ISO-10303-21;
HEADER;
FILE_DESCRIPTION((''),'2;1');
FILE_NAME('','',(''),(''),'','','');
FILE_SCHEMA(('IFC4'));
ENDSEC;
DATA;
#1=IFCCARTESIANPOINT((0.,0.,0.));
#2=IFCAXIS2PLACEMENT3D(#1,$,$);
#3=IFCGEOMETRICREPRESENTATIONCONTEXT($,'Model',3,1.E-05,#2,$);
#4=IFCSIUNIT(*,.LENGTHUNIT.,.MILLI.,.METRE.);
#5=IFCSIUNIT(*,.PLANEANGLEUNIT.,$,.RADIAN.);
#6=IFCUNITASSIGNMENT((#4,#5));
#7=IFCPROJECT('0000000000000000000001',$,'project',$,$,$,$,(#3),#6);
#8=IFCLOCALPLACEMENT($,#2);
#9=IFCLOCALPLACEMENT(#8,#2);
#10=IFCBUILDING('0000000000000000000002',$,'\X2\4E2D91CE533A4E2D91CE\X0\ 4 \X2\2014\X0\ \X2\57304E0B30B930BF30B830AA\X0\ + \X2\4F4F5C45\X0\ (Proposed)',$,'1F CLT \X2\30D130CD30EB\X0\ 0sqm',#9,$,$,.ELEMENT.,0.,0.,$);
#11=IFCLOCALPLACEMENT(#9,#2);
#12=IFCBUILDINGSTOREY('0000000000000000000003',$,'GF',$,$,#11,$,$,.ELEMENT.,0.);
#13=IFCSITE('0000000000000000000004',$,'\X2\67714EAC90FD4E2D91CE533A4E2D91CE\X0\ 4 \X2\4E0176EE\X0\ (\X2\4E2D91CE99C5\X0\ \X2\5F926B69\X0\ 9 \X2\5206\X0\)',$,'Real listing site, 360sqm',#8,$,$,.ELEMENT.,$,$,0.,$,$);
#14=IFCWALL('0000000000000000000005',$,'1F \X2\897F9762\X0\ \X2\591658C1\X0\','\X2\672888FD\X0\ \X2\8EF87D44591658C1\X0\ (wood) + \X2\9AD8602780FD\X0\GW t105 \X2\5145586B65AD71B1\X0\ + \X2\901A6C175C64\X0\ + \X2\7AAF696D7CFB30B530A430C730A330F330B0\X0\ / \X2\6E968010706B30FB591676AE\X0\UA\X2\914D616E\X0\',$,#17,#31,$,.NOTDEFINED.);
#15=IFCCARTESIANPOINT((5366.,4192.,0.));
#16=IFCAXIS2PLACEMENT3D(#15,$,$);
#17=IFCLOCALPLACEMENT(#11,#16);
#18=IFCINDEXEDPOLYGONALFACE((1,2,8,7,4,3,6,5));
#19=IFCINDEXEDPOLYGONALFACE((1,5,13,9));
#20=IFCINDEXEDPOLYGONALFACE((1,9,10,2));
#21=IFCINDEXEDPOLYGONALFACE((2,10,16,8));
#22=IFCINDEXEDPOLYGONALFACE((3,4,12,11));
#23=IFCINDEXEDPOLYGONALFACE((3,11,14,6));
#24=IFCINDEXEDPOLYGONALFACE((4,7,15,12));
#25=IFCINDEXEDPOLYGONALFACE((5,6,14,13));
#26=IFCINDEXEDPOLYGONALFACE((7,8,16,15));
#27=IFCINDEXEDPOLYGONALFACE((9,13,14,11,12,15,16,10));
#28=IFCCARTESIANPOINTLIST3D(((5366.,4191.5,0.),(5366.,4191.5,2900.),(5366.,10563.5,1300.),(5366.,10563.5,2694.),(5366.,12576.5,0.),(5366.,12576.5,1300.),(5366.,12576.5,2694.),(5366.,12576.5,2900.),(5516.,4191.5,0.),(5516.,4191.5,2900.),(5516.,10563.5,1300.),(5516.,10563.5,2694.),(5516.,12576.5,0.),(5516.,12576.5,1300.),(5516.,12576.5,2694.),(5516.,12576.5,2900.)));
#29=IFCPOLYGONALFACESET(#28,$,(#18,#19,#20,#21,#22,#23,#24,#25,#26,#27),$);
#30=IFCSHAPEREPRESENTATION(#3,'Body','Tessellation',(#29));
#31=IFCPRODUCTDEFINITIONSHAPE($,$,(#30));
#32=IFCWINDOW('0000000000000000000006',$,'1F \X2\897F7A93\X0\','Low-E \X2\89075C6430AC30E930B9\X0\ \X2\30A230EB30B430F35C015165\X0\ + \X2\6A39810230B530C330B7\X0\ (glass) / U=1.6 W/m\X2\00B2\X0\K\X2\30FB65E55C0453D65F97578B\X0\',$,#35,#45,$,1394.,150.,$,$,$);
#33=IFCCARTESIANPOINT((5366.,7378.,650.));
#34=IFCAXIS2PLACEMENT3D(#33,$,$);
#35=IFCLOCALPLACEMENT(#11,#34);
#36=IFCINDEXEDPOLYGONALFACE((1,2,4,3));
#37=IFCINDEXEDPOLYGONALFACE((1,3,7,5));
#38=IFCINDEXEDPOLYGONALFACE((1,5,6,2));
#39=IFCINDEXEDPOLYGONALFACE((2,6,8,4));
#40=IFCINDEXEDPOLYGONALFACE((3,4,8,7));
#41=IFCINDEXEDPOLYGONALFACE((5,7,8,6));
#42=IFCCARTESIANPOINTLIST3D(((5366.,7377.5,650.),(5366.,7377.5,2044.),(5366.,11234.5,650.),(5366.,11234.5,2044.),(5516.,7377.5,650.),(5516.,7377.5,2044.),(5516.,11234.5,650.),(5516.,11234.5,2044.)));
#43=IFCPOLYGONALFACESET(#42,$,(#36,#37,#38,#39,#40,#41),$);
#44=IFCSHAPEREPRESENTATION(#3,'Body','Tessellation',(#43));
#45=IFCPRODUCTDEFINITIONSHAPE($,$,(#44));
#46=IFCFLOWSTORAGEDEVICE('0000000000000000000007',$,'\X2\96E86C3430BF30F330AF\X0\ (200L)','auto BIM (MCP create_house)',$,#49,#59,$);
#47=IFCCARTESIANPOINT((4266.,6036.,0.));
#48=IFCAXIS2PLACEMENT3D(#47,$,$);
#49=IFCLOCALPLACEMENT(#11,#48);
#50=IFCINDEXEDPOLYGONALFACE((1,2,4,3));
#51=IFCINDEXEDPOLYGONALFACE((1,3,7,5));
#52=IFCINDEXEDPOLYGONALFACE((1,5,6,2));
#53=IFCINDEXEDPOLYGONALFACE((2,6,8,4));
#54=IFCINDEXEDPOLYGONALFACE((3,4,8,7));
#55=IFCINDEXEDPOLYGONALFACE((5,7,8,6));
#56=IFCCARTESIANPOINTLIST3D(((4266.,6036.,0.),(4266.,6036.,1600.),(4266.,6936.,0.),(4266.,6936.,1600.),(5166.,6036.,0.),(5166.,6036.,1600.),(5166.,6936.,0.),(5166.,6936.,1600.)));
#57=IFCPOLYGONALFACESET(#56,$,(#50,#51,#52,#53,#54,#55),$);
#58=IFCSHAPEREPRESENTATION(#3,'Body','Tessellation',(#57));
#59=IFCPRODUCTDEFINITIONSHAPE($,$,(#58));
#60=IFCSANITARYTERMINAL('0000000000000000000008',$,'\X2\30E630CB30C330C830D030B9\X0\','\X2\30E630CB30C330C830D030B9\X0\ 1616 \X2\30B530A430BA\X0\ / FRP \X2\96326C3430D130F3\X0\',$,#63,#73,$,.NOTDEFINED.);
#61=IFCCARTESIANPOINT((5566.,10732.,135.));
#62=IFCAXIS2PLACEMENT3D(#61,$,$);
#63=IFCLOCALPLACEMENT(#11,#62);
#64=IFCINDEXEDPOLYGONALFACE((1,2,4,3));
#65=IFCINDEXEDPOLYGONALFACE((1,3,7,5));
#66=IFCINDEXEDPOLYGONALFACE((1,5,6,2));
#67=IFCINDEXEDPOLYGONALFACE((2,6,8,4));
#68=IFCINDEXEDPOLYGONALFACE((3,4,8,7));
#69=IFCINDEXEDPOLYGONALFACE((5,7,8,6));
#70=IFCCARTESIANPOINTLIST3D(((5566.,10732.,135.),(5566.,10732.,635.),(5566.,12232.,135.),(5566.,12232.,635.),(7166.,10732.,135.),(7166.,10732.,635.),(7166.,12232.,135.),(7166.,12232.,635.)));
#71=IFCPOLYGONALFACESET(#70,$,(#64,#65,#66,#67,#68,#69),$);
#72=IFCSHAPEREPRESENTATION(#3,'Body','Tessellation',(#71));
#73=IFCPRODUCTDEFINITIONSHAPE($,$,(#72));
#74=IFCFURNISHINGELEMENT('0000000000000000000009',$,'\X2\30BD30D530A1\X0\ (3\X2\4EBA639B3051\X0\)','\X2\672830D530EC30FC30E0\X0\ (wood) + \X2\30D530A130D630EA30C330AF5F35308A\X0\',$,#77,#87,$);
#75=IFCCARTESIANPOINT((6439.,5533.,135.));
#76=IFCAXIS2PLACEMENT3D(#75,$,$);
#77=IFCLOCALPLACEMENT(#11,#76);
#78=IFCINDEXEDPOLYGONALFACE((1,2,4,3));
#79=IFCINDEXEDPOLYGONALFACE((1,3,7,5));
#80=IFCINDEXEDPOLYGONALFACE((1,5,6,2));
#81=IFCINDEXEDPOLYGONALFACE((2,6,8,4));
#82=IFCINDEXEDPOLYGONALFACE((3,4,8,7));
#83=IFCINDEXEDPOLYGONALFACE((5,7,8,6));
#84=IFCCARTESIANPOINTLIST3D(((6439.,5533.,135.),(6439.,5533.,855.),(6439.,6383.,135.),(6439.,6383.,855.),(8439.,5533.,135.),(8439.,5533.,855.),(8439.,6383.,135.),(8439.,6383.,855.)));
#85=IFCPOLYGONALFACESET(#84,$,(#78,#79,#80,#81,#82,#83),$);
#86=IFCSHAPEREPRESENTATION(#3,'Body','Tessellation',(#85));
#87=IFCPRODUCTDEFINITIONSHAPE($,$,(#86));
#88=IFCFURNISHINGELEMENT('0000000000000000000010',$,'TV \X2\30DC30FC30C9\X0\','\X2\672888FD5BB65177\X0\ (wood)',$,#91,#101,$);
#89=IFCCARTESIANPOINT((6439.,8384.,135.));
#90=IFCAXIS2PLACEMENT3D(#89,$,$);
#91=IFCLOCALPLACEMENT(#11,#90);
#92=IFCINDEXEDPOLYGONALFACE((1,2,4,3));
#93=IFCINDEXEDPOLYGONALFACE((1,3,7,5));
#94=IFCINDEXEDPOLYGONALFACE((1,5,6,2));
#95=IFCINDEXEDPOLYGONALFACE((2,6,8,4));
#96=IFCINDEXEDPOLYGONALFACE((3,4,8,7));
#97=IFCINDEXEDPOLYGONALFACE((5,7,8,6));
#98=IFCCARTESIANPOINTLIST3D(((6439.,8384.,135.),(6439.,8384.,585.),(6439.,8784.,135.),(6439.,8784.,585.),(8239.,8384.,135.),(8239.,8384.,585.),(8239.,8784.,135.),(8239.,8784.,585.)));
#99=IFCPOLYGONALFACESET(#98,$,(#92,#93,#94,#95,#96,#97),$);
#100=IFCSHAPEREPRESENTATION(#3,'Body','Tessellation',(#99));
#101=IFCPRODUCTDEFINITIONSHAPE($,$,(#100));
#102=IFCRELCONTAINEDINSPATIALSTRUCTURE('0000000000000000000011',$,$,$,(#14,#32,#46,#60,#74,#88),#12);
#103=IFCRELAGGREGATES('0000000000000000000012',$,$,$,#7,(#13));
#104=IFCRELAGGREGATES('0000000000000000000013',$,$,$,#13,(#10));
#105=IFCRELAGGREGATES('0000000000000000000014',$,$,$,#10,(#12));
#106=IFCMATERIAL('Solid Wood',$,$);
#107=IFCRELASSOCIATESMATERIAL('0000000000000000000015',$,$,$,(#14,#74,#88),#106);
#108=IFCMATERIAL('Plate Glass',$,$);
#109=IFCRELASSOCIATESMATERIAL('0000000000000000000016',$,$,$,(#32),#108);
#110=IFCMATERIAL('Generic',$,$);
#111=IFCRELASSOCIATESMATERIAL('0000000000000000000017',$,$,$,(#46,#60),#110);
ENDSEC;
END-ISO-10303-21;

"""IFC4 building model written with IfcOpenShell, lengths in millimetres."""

from ifc_helpers import new_model, si_unit, frame, frame_2d, origin, place, context, project, spatial, rectangle, extrude, material, element, fill, save


model = new_model("IFC4")

# Units and contexts
model_context = context("Model", 3, precision=1e-05, world=origin())
ifc_project = project(units=[si_unit("LENGTHUNIT", "METRE", prefix="MILLI"), si_unit("PLANEANGLEUNIT", "RADIAN")], contexts=[model_context])

# Site, building, storey
site_placement = place(None, origin())
site = spatial("IfcSite", under=ifc_project, at=site_placement, Name="東京都中野区中野 4 丁目 (中野駅 徒歩 9 分)", ObjectType="Real listing site, 360sqm", CompositionType="ELEMENT", RefElevation=0.0)
building_placement = place(site_placement, origin())
building = spatial("IfcBuilding", under=site, at=building_placement, Name="中野区中野 4 — 地下スタジオ + 住居 (Proposed)", ObjectType="1F CLT パネル 0sqm", CompositionType="ELEMENT", ElevationOfRefHeight=0.0, ElevationOfTerrain=0.0)
storey_placement = place(building_placement, origin())
storey = spatial("IfcBuildingStorey", under=building, at=storey_placement, Name="GF", CompositionType="ELEMENT", Elevation=0.0)

# Shared definitions
ifc_material_1 = material(Name="Solid Wood")

# Shared definitions
ifc_material_2 = material(Name="Plate Glass")

# Wall, opening, window
wall_1_placement = place(storey_placement, frame((5366.0, 4192.0, 0.0)))
wall_1 = element("IfcWall", 1, at=wall_1_placement, inside=storey, material=ifc_material_1, Name="1F 西面 外壁", Description="木製 軸組外壁 (wood) + 高性能GW t105 充填断熱 + 通気層 + 窯業系サイディング / 準耐火・外皮UA配慮", PredefinedType="NOTDEFINED", context=model_context, shape_type="SweptSolid", body=[
    extrude(rectangle(XDim=150.0, YDim=8385.0, at=frame_2d((75.0, 4192.0))), frame((5366.0, 4192.0, 0.0)), (0.0, 0.0, 1.0), 2900.0),
])
opening_1_placement = place(storey_placement, frame((5366.0, 7378.0, 650.0)))
opening_1 = element("IfcOpeningElement", 2, at=opening_1_placement, cuts=wall_1, PredefinedType="NOTDEFINED", context=model_context, shape_type="SweptSolid", body=[
    extrude(rectangle(XDim=150.0, YDim=3857.0, at=frame_2d((75.0, 1928.0))), frame((5366.0, 7378.0, 650.0)), (0.0, 0.0, 1.0), 1394.0),
])
window_1_placement = place(storey_placement, frame((5366.0, 7378.0, 650.0)))
window_1 = element("IfcWindow", 3, at=window_1_placement, inside=storey, material=ifc_material_2, Name="1F 西窓", Description="Low-E 複層ガラス アルゴン封入 + 樹脂サッシ (glass) / U=1.6 W/m²K・日射取得型", OverallHeight=1394.0, OverallWidth=150.0, context=model_context, shape_type="SweptSolid", body=[
    extrude(rectangle(XDim=150.0, YDim=3857.0, at=frame_2d((75.0, 1928.0))), frame((5366.0, 7378.0, 650.0)), (0.0, 0.0, 1.0), 1394.0),
])
fill(opening_1, window_1)

# Shared definitions
ifc_material_3 = material(Name="Generic")

# Flow storage device
flow_storage_device_placement = place(storey_placement, frame((4266.0, 6036.0, 0.0)))
element("IfcFlowStorageDevice", 4, at=flow_storage_device_placement, inside=storey, material=ifc_material_3, Name="雨水タンク (200L)", Description="auto BIM (MCP create_house)", context=model_context, shape_type="SweptSolid", body=[
    extrude(rectangle(XDim=900.0, YDim=900.0, at=frame_2d((450.0, 450.0))), frame((4266.0, 6036.0, 0.0)), (0.0, 0.0, 1.0), 1600.0),
])

# Sanitary terminal
sanitary_terminal_placement = place(storey_placement, frame((5566.0, 10732.0, 135.0)))
element("IfcSanitaryTerminal", 5, at=sanitary_terminal_placement, inside=storey, material=ifc_material_3, Name="ユニットバス", Description="ユニットバス 1616 サイズ / FRP 防水パン", PredefinedType="NOTDEFINED", context=model_context, shape_type="SweptSolid", body=[
    extrude(rectangle(XDim=1600.0, YDim=1500.0, at=frame_2d((800.0, 750.0))), frame((5566.0, 10732.0, 135.0)), (0.0, 0.0, 1.0), 500.0),
])

# Furnishing elements
furnishing_1_placement = place(storey_placement, frame((6439.0, 5533.0, 135.0)))
element("IfcFurnishingElement", 6, at=furnishing_1_placement, inside=storey, material=ifc_material_1, Name="ソファ (3人掛け)", Description="木フレーム (wood) + ファブリック張り", context=model_context, shape_type="SweptSolid", body=[
    extrude(rectangle(XDim=2000.0, YDim=850.0, at=frame_2d((1000.0, 425.0))), frame((6439.0, 5533.0, 135.0)), (0.0, 0.0, 1.0), 720.0),
])
furnishing_2_placement = place(storey_placement, frame((6439.0, 8384.0, 135.0)))
element("IfcFurnishingElement", 7, at=furnishing_2_placement, inside=storey, material=ifc_material_1, Name="TV ボード", Description="木製家具 (wood)", context=model_context, shape_type="SweptSolid", body=[
    extrude(rectangle(XDim=1800.0, YDim=400.0, at=frame_2d((900.0, 200.0))), frame((6439.0, 8384.0, 135.0)), (0.0, 0.0, 1.0), 450.0),
])

save(model, "model.ifc")
